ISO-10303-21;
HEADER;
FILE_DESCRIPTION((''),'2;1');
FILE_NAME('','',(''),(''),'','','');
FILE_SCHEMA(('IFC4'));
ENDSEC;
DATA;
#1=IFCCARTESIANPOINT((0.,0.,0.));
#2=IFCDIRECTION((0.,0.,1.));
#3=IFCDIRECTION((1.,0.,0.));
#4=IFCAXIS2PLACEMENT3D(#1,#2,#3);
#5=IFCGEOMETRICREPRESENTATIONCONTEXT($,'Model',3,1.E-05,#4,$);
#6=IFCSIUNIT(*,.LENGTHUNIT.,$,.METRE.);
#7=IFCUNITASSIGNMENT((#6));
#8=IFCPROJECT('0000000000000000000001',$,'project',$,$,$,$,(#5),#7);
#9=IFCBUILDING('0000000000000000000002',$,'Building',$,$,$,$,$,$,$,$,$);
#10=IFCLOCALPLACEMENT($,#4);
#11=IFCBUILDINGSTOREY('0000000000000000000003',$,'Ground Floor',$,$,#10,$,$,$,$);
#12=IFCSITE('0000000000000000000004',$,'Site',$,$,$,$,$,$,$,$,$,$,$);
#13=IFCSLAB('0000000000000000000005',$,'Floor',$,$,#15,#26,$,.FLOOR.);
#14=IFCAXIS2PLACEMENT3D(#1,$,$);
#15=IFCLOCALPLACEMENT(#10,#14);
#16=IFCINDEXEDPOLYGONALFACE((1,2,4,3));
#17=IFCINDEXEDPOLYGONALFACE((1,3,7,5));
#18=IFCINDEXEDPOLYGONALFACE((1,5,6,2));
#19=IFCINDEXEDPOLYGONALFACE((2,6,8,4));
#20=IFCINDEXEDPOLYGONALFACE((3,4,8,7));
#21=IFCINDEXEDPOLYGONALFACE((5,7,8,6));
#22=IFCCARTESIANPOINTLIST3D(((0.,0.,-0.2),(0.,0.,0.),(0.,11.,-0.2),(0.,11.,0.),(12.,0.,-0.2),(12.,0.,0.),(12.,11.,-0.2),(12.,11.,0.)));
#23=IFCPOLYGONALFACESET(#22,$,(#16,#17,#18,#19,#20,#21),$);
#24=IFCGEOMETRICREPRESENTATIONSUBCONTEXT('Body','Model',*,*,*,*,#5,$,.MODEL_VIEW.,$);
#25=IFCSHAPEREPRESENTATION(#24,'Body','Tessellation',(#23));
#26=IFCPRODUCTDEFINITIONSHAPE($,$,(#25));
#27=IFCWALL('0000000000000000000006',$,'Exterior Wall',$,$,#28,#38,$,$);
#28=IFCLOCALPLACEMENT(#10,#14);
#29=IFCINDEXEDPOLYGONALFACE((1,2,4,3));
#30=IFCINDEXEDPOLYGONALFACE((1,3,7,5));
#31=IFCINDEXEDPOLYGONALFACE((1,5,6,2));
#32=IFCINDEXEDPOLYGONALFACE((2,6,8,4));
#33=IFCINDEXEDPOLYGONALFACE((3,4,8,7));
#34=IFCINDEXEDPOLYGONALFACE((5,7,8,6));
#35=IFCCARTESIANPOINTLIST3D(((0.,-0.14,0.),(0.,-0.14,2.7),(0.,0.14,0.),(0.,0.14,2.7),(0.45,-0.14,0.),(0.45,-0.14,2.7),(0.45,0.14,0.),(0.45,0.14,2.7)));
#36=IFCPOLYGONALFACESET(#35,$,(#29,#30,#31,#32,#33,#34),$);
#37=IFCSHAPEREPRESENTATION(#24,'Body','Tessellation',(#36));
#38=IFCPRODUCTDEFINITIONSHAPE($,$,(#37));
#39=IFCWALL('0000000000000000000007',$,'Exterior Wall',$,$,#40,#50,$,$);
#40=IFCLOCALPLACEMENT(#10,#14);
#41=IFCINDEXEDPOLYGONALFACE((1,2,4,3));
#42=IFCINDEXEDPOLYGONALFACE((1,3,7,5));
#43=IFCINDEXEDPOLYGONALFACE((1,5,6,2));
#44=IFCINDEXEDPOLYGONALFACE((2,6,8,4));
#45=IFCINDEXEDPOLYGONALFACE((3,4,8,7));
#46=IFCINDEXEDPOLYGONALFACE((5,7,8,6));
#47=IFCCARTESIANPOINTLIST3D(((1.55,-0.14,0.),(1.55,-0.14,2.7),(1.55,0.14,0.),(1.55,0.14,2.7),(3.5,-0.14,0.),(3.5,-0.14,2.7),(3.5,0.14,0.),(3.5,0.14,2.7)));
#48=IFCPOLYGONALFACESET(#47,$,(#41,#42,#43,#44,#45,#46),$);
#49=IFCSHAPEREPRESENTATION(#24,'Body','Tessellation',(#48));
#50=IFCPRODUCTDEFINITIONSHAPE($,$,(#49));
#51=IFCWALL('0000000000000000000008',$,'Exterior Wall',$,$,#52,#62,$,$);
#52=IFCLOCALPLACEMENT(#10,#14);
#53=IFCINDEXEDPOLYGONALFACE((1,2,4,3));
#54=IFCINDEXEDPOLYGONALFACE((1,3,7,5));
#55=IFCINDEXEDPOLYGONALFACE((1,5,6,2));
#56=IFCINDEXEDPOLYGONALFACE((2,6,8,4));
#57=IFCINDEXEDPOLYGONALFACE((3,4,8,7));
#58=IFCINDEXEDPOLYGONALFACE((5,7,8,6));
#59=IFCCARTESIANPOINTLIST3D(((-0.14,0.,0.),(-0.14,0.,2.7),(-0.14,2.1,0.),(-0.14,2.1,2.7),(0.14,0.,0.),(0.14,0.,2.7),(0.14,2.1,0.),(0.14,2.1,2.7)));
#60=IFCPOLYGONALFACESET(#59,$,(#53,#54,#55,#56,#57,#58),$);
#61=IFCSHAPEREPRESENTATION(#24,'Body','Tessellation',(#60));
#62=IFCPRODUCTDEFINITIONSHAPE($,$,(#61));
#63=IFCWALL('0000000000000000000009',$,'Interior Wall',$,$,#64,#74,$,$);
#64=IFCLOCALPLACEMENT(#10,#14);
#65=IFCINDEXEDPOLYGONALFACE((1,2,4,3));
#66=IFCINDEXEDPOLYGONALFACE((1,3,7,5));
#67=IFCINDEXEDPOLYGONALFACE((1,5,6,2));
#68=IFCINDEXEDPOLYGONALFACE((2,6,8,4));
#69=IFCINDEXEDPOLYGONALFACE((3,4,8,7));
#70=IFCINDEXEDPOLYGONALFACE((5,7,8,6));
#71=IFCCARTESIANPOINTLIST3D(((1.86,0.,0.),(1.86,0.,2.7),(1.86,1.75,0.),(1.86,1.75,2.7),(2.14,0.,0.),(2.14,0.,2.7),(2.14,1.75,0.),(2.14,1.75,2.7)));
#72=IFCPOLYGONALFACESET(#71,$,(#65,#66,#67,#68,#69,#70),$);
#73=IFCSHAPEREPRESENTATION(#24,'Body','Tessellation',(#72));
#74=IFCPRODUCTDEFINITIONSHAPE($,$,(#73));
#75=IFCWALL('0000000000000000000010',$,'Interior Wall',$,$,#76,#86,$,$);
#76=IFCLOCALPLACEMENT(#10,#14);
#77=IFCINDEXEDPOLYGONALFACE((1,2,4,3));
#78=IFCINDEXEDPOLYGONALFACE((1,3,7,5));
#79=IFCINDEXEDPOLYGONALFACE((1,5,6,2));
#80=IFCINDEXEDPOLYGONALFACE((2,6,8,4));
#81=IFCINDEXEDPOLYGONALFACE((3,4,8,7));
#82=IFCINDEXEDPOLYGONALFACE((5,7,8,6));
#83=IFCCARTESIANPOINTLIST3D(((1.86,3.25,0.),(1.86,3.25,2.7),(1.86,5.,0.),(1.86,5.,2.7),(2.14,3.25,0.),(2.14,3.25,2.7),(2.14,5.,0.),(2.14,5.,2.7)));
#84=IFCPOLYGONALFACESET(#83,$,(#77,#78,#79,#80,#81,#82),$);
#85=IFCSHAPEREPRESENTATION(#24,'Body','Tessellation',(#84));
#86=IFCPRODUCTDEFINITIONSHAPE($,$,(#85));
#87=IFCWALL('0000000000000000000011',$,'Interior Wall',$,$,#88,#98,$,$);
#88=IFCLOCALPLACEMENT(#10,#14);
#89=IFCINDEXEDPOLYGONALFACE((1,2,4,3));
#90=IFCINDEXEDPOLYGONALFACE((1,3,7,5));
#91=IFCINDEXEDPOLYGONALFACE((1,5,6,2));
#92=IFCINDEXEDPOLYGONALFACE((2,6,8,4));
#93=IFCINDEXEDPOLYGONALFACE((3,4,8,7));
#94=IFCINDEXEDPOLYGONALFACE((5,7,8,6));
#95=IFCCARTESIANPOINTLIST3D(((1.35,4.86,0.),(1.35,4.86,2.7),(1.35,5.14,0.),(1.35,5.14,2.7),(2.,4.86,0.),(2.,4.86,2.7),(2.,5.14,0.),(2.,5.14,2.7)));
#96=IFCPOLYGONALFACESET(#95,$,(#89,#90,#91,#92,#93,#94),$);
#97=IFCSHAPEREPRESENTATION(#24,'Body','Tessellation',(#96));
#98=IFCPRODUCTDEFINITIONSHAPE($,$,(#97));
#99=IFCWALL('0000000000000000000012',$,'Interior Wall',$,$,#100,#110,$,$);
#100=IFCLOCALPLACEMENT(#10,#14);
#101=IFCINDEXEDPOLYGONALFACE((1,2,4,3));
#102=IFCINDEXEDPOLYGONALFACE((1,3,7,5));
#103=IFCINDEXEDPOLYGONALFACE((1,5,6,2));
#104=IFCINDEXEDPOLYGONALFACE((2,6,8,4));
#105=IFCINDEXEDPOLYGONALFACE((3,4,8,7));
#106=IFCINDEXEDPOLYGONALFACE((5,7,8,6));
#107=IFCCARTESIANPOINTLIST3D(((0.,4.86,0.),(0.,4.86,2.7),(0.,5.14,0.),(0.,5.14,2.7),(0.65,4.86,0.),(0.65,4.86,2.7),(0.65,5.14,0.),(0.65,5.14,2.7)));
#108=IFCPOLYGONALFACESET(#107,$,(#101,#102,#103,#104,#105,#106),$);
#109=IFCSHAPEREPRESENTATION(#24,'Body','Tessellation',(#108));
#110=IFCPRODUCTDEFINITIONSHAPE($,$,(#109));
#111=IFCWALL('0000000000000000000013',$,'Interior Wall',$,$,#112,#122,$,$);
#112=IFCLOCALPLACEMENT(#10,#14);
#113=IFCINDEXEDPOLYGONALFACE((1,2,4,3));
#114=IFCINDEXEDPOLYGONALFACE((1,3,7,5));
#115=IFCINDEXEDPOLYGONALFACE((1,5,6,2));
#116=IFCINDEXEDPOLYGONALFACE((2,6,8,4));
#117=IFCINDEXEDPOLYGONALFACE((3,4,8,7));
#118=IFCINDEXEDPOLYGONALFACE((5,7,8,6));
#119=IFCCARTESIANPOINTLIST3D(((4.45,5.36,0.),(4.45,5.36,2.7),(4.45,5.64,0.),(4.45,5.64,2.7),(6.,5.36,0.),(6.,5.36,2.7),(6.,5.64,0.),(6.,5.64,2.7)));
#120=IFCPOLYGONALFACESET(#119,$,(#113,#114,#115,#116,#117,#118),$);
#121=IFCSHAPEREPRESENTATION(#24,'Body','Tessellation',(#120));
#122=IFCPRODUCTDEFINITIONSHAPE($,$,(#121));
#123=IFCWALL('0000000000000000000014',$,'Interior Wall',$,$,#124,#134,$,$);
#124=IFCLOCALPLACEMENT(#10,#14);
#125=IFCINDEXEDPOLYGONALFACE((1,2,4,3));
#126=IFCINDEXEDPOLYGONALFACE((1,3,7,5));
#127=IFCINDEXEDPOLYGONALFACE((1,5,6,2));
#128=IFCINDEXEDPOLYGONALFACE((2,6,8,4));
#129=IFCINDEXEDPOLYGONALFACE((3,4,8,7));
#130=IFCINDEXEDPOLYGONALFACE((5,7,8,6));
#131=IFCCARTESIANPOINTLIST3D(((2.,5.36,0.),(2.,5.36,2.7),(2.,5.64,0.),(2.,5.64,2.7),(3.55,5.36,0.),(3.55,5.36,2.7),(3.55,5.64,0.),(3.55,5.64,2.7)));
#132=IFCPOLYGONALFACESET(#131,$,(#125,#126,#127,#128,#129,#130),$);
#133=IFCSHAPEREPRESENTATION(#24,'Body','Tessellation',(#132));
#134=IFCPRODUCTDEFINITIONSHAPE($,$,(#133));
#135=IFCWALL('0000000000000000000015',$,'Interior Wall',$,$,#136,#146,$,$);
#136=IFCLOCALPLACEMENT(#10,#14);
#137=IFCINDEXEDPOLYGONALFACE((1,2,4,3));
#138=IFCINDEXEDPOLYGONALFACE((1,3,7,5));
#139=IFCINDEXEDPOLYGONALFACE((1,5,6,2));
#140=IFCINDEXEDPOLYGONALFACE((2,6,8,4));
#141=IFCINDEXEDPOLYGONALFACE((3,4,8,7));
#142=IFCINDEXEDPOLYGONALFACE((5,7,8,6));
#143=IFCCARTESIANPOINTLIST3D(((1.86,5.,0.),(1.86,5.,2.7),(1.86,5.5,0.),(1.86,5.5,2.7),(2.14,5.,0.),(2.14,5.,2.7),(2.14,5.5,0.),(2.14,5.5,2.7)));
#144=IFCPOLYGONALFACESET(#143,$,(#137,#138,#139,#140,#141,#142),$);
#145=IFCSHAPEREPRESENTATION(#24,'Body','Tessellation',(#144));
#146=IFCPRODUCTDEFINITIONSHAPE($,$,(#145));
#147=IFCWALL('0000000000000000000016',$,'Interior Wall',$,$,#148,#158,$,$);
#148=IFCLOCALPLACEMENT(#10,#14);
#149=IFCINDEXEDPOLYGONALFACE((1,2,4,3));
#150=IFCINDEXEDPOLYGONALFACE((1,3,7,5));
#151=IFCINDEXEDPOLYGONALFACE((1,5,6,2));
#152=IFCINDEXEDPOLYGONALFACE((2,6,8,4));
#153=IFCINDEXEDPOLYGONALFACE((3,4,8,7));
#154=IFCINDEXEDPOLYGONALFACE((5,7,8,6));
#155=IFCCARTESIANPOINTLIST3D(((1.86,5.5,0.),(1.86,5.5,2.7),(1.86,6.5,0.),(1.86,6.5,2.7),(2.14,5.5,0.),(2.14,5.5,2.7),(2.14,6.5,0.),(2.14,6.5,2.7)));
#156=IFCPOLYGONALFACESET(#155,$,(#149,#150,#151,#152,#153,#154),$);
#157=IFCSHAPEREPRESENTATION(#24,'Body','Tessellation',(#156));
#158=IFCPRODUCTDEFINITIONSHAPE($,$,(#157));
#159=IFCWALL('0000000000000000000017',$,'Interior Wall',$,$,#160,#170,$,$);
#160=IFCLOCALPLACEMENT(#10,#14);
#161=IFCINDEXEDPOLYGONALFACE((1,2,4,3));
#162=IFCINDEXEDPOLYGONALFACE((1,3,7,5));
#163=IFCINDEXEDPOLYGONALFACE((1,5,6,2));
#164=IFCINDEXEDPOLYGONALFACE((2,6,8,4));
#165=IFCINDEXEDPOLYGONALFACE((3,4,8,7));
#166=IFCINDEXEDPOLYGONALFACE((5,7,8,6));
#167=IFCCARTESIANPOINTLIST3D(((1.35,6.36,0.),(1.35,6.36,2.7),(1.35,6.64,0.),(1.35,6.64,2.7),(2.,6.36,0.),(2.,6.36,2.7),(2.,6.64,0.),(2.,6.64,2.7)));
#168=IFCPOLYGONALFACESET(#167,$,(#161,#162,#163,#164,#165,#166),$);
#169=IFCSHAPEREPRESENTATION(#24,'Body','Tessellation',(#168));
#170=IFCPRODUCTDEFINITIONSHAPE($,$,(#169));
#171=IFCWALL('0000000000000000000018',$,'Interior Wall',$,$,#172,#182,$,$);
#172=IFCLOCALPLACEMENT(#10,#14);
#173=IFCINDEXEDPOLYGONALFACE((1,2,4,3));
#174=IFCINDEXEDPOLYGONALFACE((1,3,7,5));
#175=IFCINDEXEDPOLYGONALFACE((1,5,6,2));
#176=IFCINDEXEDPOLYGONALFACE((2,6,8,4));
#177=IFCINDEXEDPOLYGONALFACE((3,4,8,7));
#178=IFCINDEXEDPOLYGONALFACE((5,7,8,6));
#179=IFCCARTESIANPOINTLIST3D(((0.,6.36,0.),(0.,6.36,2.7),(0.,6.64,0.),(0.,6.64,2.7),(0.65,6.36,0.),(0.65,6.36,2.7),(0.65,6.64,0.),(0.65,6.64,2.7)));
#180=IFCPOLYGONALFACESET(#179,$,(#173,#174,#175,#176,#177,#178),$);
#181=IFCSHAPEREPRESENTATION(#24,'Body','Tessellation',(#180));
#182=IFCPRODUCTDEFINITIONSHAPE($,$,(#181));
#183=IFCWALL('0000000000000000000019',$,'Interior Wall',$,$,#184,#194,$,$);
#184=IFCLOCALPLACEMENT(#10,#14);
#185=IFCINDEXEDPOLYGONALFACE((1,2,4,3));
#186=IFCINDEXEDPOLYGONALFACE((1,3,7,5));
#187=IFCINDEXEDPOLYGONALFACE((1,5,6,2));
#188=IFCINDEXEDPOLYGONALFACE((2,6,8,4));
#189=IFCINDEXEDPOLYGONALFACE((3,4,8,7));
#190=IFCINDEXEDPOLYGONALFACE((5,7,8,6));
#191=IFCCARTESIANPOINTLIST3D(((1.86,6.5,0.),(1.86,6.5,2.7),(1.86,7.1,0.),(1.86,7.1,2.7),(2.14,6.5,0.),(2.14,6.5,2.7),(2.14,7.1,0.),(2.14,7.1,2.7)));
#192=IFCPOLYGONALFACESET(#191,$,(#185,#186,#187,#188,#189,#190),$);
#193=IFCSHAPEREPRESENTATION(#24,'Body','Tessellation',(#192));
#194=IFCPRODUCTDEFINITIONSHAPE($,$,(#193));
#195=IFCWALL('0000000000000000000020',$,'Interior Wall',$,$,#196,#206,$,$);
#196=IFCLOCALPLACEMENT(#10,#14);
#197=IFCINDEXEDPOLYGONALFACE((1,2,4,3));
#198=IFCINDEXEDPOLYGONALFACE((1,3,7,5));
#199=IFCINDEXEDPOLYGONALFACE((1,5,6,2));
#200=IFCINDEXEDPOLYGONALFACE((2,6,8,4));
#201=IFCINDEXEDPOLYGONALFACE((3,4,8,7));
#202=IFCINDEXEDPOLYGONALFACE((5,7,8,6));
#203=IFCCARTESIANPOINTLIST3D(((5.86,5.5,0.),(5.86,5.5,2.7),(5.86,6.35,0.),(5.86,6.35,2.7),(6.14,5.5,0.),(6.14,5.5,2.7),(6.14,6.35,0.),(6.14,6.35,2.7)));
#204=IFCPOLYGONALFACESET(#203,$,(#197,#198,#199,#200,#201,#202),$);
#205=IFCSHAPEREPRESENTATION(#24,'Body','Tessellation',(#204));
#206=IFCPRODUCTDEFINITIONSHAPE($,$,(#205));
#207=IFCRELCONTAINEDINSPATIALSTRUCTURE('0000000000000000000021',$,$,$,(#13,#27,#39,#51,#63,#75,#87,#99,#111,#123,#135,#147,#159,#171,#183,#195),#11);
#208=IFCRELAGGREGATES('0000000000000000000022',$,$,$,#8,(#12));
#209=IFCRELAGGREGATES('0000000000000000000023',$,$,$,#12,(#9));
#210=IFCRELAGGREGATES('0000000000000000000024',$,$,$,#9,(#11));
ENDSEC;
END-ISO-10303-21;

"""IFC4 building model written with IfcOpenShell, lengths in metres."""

from ifc_helpers import new_model, si_unit, frame, origin_with_axes, place, context, subcontext, project, spatial, indexed_curve, outline, extrude, element, save


model = new_model("IFC4")

# Units and contexts
model_context = context("Model", 3, precision=1e-05, world=origin_with_axes())
body_context = subcontext(model_context, "Body", "Model", "MODEL_VIEW")
ifc_project = project(units=[si_unit("LENGTHUNIT", "METRE")], contexts=[model_context])

# Site, building, storey
site = spatial("IfcSite", under=ifc_project, Name="Site")
building = spatial("IfcBuilding", under=site, Name="Building")
storey_placement = place(None, origin_with_axes())
storey = spatial("IfcBuildingStorey", under=building, at=storey_placement, Name="Ground Floor")

# Slab
slab_placement = place(storey_placement, frame((0.0, 0.0, -0.2), z_axis=(0.0, 0.0, 1.0), x_axis=(1.0, 0.0, 0.0)))
element("IfcSlab", 1, at=slab_placement, inside=storey, Name="Floor", PredefinedType="FLOOR", context=body_context, shape_type="SweptSolid", body=[
    extrude(outline(indexed_curve([(0.0, 0.0), (12.0, 0.0), (12.0, 11.0), (0.0, 11.0)])), None, (0.0, 0.0, 1.0), 0.2),
])

# Walls
wall_1_placement = place(storey_placement, origin_with_axes())
element("IfcWall", 2, at=wall_1_placement, inside=storey, Name="Exterior Wall", context=body_context, shape_type="SweptSolid", body=[
    extrude(outline(indexed_curve([(0.0, 0.0), (0.0, 0.28), (0.45, 0.28), (0.45, 0.0), (0.0, 0.0)], self_intersect=False)), frame((0.0, -0.14, 0.0), z_axis=(0.0, 0.0, 1.0), x_axis=(1.0, 0.0, 0.0)), (0.0, 0.0, 1.0), 2.7),
])
wall_2_placement = place(storey_placement, frame((1.55, 0.0, 0.0), z_axis=(0.0, 0.0, 1.0), x_axis=(1.0, 0.0, 0.0)))
element("IfcWall", 3, at=wall_2_placement, inside=storey, Name="Exterior Wall", context=body_context, shape_type="SweptSolid", body=[
    extrude(outline(indexed_curve([(0.0, 0.0), (0.0, 0.28), (1.95, 0.28), (1.95, 0.0), (0.0, 0.0)], self_intersect=False)), frame((0.0, -0.14, 0.0), z_axis=(0.0, 0.0, 1.0), x_axis=(1.0, 0.0, 0.0)), (0.0, 0.0, 1.0), 2.7),
])
wall_3_placement = place(storey_placement, frame((0.0, 2.1, 0.0), z_axis=(0.0, 0.0, 1.0), x_axis=(0.0, -1.0, 0.0)))
element("IfcWall", 4, at=wall_3_placement, inside=storey, Name="Exterior Wall", context=body_context, shape_type="SweptSolid", body=[
    extrude(outline(indexed_curve([(0.0, 0.0), (0.0, 0.28), (2.1, 0.28), (2.1, 0.0), (0.0, 0.0)], self_intersect=False)), frame((0.0, -0.14, 0.0), z_axis=(0.0, 0.0, 1.0), x_axis=(1.0, 0.0, 0.0)), (0.0, 0.0, 1.0), 2.7),
])
for number, where, z_axis, x_axis, name in (
    (5, (2.0, 0.0, 0.0), (0.0, 0.0, 1.0), (0.0, 1.0, 0.0), "Interior Wall"),
    (6, (2.0, 3.25, 0.0), (0.0, 0.0, 1.0), (0.0, 1.0, 0.0), "Interior Wall"),
):
    element("IfcWall", number, at=place(storey_placement, frame(where, z_axis=z_axis, x_axis=x_axis)), inside=storey, Name=name, context=body_context, shape_type="SweptSolid", body=[
        extrude(outline(indexed_curve([(0.0, 0.0), (0.0, 0.28), (1.75, 0.28), (1.75, 0.0), (0.0, 0.0)], self_intersect=False)), frame((0.0, -0.14, 0.0), z_axis=(0.0, 0.0, 1.0), x_axis=(1.0, 0.0, 0.0)), (0.0, 0.0, 1.0), 2.7),
    ])
for number, where, z_axis, x_axis, name in (
    (7, (2.0, 5.0, 0.0), (0.0, 0.0, 1.0), (-1.0, 0.0, 0.0), "Interior Wall"),
    (8, (0.65, 5.0, 0.0), (0.0, 0.0, 1.0), (-1.0, 0.0, 0.0), "Interior Wall"),
):
    element("IfcWall", number, at=place(storey_placement, frame(where, z_axis=z_axis, x_axis=x_axis)), inside=storey, Name=name, context=body_context, shape_type="SweptSolid", body=[
        extrude(outline(indexed_curve([(0.0, 0.0), (0.0, 0.28), (0.65, 0.28), (0.65, 0.0), (0.0, 0.0)], self_intersect=False)), frame((0.0, -0.14, 0.0), z_axis=(0.0, 0.0, 1.0), x_axis=(1.0, 0.0, 0.0)), (0.0, 0.0, 1.0), 2.7),
    ])
for number, where, z_axis, x_axis, name in (
    (9, (6.0, 5.5, 0.0), (0.0, 0.0, 1.0), (-1.0, 0.0, 0.0), "Interior Wall"),
    (10, (3.55, 5.5, 0.0), (0.0, 0.0, 1.0), (-1.0, 0.0, 0.0), "Interior Wall"),
):
    element("IfcWall", number, at=place(storey_placement, frame(where, z_axis=z_axis, x_axis=x_axis)), inside=storey, Name=name, context=body_context, shape_type="SweptSolid", body=[
        extrude(outline(indexed_curve([(0.0, 0.0), (0.0, 0.28), (1.55, 0.28), (1.55, 0.0), (0.0, 0.0)], self_intersect=False)), frame((0.0, -0.14, 0.0), z_axis=(0.0, 0.0, 1.0), x_axis=(1.0, 0.0, 0.0)), (0.0, 0.0, 1.0), 2.7),
    ])
wall_4_placement = place(storey_placement, frame((2.0, 5.5, 0.0), z_axis=(0.0, 0.0, 1.0), x_axis=(0.0, -1.0, 0.0)))
element("IfcWall", 11, at=wall_4_placement, inside=storey, Name="Interior Wall", context=body_context, shape_type="SweptSolid", body=[
    extrude(outline(indexed_curve([(0.0, 0.0), (0.0, 0.28), (0.5, 0.28), (0.5, 0.0), (0.0, 0.0)], self_intersect=False)), frame((0.0, -0.14, 0.0), z_axis=(0.0, 0.0, 1.0), x_axis=(1.0, 0.0, 0.0)), (0.0, 0.0, 1.0), 2.7),
])
wall_5_placement = place(storey_placement, frame((2.0, 5.5, 0.0), z_axis=(0.0, 0.0, 1.0), x_axis=(0.0, 1.0, 0.0)))
element("IfcWall", 12, at=wall_5_placement, inside=storey, Name="Interior Wall", context=body_context, shape_type="SweptSolid", body=[
    extrude(outline(indexed_curve([(0.0, 0.0), (0.0, 0.28), (1.0, 0.28), (1.0, 0.0), (0.0, 0.0)], self_intersect=False)), frame((0.0, -0.14, 0.0), z_axis=(0.0, 0.0, 1.0), x_axis=(1.0, 0.0, 0.0)), (0.0, 0.0, 1.0), 2.7),
])
for number, where, z_axis, x_axis, name in (
    (13, (2.0, 6.5, 0.0), (0.0, 0.0, 1.0), (-1.0, 0.0, 0.0), "Interior Wall"),
    (14, (0.65, 6.5, 0.0), (0.0, 0.0, 1.0), (-1.0, 0.0, 0.0), "Interior Wall"),
):
    element("IfcWall", number, at=place(storey_placement, frame(where, z_axis=z_axis, x_axis=x_axis)), inside=storey, Name=name, context=body_context, shape_type="SweptSolid", body=[
        extrude(outline(indexed_curve([(0.0, 0.0), (0.0, 0.28), (0.65, 0.28), (0.65, 0.0), (0.0, 0.0)], self_intersect=False)), frame((0.0, -0.14, 0.0), z_axis=(0.0, 0.0, 1.0), x_axis=(1.0, 0.0, 0.0)), (0.0, 0.0, 1.0), 2.7),
    ])
wall_6_placement = place(storey_placement, frame((2.0, 6.5, 0.0), z_axis=(0.0, 0.0, 1.0), x_axis=(0.0, 1.0, 0.0)))
element("IfcWall", 15, at=wall_6_placement, inside=storey, Name="Interior Wall", context=body_context, shape_type="SweptSolid", body=[
    extrude(outline(indexed_curve([(0.0, 0.0), (0.0, 0.28), (0.6, 0.28), (0.6, 0.0), (0.0, 0.0)], self_intersect=False)), frame((0.0, -0.14, 0.0), z_axis=(0.0, 0.0, 1.0), x_axis=(1.0, 0.0, 0.0)), (0.0, 0.0, 1.0), 2.7),
])
wall_7_placement = place(storey_placement, frame((6.0, 5.5, 0.0), z_axis=(0.0, 0.0, 1.0), x_axis=(0.0, 1.0, 0.0)))
element("IfcWall", 16, at=wall_7_placement, inside=storey, Name="Interior Wall", context=body_context, shape_type="SweptSolid", body=[
    extrude(outline(indexed_curve([(0.0, 0.0), (0.0, 0.28), (0.85, 0.28), (0.85, 0.0), (0.0, 0.0)], self_intersect=False)), frame((0.0, -0.14, 0.0), z_axis=(0.0, 0.0, 1.0), x_axis=(1.0, 0.0, 0.0)), (0.0, 0.0, 1.0), 2.7),
])

save(model, "model.ifc")
